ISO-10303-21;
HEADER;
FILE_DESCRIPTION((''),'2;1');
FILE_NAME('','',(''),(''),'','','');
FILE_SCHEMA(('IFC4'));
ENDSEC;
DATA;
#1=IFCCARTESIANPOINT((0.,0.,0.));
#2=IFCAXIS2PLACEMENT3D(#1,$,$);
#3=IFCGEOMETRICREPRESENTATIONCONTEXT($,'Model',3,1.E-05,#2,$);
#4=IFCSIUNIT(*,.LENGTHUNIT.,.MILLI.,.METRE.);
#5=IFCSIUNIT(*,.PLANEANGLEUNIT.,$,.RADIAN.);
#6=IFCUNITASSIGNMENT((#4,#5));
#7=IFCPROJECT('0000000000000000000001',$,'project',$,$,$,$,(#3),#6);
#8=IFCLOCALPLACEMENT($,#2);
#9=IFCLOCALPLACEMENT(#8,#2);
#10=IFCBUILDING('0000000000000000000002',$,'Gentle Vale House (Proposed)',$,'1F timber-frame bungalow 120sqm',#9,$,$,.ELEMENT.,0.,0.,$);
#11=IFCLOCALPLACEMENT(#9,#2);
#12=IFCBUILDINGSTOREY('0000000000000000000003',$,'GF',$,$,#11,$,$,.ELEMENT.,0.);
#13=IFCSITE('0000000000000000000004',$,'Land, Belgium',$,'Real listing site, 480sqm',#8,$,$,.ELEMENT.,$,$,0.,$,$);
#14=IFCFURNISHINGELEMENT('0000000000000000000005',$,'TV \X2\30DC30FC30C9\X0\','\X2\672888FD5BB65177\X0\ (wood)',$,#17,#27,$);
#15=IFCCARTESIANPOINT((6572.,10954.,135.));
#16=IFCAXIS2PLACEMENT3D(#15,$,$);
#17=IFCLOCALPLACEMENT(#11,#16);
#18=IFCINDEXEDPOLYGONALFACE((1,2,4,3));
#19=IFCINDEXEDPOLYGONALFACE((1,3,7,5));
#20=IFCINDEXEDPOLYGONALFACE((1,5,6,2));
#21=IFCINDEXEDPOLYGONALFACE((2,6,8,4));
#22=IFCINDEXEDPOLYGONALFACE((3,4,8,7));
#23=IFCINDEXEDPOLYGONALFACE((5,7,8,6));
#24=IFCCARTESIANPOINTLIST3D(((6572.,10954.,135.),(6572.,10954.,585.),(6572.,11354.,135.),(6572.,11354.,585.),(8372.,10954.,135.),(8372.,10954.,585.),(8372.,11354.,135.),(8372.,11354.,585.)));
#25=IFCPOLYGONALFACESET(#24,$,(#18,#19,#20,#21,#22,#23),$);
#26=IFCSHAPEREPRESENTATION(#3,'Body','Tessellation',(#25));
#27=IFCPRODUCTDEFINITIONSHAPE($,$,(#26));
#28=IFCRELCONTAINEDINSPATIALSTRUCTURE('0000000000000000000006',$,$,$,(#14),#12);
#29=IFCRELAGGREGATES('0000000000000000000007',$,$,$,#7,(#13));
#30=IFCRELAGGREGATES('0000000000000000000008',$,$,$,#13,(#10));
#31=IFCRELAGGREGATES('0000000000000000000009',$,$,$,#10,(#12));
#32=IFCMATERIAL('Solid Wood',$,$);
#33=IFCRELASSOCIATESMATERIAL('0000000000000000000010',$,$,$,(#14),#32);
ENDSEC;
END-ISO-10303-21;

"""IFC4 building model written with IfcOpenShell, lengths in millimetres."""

from ifc_helpers import new_model, si_unit, frame, frame_2d, origin, place, context, project, spatial, rectangle, extrude, material, element, save


model = new_model("IFC4")

# Units and contexts
model_context = context("Model", 3, precision=1e-05, world=origin())
ifc_project = project(units=[si_unit("LENGTHUNIT", "METRE", prefix="MILLI"), si_unit("PLANEANGLEUNIT", "RADIAN")], contexts=[model_context])

# Site, building, storey
site_placement = place(None, origin())
site = spatial("IfcSite", under=ifc_project, at=site_placement, Name="Land, Belgium", ObjectType="Real listing site, 480sqm", CompositionType="ELEMENT", RefElevation=0.0)
building_placement = place(site_placement, origin())
building = spatial("IfcBuilding", under=site, at=building_placement, Name="Gentle Vale House (Proposed)", ObjectType="1F timber-frame bungalow 120sqm", CompositionType="ELEMENT", ElevationOfRefHeight=0.0, ElevationOfTerrain=0.0)
storey_placement = place(building_placement, origin())
storey = spatial("IfcBuildingStorey", under=building, at=storey_placement, Name="GF", CompositionType="ELEMENT", Elevation=0.0)

# Shared definitions
ifc_material_1 = material(Name="Solid Wood")

# Furnishing element
furnishing_1_placement = place(storey_placement, frame((6572.0, 10954.0, 135.0)))
element("IfcFurnishingElement", 1, at=furnishing_1_placement, inside=storey, material=ifc_material_1, Name="TV ボード", Description="木製家具 (wood)", context=model_context, shape_type="SweptSolid", body=[
    extrude(rectangle(XDim=1800.0, YDim=400.0, at=frame_2d((900.0, 200.0))), frame((6572.0, 10954.0, 135.0)), (0.0, 0.0, 1.0), 450.0),
])

save(model, "model.ifc")
